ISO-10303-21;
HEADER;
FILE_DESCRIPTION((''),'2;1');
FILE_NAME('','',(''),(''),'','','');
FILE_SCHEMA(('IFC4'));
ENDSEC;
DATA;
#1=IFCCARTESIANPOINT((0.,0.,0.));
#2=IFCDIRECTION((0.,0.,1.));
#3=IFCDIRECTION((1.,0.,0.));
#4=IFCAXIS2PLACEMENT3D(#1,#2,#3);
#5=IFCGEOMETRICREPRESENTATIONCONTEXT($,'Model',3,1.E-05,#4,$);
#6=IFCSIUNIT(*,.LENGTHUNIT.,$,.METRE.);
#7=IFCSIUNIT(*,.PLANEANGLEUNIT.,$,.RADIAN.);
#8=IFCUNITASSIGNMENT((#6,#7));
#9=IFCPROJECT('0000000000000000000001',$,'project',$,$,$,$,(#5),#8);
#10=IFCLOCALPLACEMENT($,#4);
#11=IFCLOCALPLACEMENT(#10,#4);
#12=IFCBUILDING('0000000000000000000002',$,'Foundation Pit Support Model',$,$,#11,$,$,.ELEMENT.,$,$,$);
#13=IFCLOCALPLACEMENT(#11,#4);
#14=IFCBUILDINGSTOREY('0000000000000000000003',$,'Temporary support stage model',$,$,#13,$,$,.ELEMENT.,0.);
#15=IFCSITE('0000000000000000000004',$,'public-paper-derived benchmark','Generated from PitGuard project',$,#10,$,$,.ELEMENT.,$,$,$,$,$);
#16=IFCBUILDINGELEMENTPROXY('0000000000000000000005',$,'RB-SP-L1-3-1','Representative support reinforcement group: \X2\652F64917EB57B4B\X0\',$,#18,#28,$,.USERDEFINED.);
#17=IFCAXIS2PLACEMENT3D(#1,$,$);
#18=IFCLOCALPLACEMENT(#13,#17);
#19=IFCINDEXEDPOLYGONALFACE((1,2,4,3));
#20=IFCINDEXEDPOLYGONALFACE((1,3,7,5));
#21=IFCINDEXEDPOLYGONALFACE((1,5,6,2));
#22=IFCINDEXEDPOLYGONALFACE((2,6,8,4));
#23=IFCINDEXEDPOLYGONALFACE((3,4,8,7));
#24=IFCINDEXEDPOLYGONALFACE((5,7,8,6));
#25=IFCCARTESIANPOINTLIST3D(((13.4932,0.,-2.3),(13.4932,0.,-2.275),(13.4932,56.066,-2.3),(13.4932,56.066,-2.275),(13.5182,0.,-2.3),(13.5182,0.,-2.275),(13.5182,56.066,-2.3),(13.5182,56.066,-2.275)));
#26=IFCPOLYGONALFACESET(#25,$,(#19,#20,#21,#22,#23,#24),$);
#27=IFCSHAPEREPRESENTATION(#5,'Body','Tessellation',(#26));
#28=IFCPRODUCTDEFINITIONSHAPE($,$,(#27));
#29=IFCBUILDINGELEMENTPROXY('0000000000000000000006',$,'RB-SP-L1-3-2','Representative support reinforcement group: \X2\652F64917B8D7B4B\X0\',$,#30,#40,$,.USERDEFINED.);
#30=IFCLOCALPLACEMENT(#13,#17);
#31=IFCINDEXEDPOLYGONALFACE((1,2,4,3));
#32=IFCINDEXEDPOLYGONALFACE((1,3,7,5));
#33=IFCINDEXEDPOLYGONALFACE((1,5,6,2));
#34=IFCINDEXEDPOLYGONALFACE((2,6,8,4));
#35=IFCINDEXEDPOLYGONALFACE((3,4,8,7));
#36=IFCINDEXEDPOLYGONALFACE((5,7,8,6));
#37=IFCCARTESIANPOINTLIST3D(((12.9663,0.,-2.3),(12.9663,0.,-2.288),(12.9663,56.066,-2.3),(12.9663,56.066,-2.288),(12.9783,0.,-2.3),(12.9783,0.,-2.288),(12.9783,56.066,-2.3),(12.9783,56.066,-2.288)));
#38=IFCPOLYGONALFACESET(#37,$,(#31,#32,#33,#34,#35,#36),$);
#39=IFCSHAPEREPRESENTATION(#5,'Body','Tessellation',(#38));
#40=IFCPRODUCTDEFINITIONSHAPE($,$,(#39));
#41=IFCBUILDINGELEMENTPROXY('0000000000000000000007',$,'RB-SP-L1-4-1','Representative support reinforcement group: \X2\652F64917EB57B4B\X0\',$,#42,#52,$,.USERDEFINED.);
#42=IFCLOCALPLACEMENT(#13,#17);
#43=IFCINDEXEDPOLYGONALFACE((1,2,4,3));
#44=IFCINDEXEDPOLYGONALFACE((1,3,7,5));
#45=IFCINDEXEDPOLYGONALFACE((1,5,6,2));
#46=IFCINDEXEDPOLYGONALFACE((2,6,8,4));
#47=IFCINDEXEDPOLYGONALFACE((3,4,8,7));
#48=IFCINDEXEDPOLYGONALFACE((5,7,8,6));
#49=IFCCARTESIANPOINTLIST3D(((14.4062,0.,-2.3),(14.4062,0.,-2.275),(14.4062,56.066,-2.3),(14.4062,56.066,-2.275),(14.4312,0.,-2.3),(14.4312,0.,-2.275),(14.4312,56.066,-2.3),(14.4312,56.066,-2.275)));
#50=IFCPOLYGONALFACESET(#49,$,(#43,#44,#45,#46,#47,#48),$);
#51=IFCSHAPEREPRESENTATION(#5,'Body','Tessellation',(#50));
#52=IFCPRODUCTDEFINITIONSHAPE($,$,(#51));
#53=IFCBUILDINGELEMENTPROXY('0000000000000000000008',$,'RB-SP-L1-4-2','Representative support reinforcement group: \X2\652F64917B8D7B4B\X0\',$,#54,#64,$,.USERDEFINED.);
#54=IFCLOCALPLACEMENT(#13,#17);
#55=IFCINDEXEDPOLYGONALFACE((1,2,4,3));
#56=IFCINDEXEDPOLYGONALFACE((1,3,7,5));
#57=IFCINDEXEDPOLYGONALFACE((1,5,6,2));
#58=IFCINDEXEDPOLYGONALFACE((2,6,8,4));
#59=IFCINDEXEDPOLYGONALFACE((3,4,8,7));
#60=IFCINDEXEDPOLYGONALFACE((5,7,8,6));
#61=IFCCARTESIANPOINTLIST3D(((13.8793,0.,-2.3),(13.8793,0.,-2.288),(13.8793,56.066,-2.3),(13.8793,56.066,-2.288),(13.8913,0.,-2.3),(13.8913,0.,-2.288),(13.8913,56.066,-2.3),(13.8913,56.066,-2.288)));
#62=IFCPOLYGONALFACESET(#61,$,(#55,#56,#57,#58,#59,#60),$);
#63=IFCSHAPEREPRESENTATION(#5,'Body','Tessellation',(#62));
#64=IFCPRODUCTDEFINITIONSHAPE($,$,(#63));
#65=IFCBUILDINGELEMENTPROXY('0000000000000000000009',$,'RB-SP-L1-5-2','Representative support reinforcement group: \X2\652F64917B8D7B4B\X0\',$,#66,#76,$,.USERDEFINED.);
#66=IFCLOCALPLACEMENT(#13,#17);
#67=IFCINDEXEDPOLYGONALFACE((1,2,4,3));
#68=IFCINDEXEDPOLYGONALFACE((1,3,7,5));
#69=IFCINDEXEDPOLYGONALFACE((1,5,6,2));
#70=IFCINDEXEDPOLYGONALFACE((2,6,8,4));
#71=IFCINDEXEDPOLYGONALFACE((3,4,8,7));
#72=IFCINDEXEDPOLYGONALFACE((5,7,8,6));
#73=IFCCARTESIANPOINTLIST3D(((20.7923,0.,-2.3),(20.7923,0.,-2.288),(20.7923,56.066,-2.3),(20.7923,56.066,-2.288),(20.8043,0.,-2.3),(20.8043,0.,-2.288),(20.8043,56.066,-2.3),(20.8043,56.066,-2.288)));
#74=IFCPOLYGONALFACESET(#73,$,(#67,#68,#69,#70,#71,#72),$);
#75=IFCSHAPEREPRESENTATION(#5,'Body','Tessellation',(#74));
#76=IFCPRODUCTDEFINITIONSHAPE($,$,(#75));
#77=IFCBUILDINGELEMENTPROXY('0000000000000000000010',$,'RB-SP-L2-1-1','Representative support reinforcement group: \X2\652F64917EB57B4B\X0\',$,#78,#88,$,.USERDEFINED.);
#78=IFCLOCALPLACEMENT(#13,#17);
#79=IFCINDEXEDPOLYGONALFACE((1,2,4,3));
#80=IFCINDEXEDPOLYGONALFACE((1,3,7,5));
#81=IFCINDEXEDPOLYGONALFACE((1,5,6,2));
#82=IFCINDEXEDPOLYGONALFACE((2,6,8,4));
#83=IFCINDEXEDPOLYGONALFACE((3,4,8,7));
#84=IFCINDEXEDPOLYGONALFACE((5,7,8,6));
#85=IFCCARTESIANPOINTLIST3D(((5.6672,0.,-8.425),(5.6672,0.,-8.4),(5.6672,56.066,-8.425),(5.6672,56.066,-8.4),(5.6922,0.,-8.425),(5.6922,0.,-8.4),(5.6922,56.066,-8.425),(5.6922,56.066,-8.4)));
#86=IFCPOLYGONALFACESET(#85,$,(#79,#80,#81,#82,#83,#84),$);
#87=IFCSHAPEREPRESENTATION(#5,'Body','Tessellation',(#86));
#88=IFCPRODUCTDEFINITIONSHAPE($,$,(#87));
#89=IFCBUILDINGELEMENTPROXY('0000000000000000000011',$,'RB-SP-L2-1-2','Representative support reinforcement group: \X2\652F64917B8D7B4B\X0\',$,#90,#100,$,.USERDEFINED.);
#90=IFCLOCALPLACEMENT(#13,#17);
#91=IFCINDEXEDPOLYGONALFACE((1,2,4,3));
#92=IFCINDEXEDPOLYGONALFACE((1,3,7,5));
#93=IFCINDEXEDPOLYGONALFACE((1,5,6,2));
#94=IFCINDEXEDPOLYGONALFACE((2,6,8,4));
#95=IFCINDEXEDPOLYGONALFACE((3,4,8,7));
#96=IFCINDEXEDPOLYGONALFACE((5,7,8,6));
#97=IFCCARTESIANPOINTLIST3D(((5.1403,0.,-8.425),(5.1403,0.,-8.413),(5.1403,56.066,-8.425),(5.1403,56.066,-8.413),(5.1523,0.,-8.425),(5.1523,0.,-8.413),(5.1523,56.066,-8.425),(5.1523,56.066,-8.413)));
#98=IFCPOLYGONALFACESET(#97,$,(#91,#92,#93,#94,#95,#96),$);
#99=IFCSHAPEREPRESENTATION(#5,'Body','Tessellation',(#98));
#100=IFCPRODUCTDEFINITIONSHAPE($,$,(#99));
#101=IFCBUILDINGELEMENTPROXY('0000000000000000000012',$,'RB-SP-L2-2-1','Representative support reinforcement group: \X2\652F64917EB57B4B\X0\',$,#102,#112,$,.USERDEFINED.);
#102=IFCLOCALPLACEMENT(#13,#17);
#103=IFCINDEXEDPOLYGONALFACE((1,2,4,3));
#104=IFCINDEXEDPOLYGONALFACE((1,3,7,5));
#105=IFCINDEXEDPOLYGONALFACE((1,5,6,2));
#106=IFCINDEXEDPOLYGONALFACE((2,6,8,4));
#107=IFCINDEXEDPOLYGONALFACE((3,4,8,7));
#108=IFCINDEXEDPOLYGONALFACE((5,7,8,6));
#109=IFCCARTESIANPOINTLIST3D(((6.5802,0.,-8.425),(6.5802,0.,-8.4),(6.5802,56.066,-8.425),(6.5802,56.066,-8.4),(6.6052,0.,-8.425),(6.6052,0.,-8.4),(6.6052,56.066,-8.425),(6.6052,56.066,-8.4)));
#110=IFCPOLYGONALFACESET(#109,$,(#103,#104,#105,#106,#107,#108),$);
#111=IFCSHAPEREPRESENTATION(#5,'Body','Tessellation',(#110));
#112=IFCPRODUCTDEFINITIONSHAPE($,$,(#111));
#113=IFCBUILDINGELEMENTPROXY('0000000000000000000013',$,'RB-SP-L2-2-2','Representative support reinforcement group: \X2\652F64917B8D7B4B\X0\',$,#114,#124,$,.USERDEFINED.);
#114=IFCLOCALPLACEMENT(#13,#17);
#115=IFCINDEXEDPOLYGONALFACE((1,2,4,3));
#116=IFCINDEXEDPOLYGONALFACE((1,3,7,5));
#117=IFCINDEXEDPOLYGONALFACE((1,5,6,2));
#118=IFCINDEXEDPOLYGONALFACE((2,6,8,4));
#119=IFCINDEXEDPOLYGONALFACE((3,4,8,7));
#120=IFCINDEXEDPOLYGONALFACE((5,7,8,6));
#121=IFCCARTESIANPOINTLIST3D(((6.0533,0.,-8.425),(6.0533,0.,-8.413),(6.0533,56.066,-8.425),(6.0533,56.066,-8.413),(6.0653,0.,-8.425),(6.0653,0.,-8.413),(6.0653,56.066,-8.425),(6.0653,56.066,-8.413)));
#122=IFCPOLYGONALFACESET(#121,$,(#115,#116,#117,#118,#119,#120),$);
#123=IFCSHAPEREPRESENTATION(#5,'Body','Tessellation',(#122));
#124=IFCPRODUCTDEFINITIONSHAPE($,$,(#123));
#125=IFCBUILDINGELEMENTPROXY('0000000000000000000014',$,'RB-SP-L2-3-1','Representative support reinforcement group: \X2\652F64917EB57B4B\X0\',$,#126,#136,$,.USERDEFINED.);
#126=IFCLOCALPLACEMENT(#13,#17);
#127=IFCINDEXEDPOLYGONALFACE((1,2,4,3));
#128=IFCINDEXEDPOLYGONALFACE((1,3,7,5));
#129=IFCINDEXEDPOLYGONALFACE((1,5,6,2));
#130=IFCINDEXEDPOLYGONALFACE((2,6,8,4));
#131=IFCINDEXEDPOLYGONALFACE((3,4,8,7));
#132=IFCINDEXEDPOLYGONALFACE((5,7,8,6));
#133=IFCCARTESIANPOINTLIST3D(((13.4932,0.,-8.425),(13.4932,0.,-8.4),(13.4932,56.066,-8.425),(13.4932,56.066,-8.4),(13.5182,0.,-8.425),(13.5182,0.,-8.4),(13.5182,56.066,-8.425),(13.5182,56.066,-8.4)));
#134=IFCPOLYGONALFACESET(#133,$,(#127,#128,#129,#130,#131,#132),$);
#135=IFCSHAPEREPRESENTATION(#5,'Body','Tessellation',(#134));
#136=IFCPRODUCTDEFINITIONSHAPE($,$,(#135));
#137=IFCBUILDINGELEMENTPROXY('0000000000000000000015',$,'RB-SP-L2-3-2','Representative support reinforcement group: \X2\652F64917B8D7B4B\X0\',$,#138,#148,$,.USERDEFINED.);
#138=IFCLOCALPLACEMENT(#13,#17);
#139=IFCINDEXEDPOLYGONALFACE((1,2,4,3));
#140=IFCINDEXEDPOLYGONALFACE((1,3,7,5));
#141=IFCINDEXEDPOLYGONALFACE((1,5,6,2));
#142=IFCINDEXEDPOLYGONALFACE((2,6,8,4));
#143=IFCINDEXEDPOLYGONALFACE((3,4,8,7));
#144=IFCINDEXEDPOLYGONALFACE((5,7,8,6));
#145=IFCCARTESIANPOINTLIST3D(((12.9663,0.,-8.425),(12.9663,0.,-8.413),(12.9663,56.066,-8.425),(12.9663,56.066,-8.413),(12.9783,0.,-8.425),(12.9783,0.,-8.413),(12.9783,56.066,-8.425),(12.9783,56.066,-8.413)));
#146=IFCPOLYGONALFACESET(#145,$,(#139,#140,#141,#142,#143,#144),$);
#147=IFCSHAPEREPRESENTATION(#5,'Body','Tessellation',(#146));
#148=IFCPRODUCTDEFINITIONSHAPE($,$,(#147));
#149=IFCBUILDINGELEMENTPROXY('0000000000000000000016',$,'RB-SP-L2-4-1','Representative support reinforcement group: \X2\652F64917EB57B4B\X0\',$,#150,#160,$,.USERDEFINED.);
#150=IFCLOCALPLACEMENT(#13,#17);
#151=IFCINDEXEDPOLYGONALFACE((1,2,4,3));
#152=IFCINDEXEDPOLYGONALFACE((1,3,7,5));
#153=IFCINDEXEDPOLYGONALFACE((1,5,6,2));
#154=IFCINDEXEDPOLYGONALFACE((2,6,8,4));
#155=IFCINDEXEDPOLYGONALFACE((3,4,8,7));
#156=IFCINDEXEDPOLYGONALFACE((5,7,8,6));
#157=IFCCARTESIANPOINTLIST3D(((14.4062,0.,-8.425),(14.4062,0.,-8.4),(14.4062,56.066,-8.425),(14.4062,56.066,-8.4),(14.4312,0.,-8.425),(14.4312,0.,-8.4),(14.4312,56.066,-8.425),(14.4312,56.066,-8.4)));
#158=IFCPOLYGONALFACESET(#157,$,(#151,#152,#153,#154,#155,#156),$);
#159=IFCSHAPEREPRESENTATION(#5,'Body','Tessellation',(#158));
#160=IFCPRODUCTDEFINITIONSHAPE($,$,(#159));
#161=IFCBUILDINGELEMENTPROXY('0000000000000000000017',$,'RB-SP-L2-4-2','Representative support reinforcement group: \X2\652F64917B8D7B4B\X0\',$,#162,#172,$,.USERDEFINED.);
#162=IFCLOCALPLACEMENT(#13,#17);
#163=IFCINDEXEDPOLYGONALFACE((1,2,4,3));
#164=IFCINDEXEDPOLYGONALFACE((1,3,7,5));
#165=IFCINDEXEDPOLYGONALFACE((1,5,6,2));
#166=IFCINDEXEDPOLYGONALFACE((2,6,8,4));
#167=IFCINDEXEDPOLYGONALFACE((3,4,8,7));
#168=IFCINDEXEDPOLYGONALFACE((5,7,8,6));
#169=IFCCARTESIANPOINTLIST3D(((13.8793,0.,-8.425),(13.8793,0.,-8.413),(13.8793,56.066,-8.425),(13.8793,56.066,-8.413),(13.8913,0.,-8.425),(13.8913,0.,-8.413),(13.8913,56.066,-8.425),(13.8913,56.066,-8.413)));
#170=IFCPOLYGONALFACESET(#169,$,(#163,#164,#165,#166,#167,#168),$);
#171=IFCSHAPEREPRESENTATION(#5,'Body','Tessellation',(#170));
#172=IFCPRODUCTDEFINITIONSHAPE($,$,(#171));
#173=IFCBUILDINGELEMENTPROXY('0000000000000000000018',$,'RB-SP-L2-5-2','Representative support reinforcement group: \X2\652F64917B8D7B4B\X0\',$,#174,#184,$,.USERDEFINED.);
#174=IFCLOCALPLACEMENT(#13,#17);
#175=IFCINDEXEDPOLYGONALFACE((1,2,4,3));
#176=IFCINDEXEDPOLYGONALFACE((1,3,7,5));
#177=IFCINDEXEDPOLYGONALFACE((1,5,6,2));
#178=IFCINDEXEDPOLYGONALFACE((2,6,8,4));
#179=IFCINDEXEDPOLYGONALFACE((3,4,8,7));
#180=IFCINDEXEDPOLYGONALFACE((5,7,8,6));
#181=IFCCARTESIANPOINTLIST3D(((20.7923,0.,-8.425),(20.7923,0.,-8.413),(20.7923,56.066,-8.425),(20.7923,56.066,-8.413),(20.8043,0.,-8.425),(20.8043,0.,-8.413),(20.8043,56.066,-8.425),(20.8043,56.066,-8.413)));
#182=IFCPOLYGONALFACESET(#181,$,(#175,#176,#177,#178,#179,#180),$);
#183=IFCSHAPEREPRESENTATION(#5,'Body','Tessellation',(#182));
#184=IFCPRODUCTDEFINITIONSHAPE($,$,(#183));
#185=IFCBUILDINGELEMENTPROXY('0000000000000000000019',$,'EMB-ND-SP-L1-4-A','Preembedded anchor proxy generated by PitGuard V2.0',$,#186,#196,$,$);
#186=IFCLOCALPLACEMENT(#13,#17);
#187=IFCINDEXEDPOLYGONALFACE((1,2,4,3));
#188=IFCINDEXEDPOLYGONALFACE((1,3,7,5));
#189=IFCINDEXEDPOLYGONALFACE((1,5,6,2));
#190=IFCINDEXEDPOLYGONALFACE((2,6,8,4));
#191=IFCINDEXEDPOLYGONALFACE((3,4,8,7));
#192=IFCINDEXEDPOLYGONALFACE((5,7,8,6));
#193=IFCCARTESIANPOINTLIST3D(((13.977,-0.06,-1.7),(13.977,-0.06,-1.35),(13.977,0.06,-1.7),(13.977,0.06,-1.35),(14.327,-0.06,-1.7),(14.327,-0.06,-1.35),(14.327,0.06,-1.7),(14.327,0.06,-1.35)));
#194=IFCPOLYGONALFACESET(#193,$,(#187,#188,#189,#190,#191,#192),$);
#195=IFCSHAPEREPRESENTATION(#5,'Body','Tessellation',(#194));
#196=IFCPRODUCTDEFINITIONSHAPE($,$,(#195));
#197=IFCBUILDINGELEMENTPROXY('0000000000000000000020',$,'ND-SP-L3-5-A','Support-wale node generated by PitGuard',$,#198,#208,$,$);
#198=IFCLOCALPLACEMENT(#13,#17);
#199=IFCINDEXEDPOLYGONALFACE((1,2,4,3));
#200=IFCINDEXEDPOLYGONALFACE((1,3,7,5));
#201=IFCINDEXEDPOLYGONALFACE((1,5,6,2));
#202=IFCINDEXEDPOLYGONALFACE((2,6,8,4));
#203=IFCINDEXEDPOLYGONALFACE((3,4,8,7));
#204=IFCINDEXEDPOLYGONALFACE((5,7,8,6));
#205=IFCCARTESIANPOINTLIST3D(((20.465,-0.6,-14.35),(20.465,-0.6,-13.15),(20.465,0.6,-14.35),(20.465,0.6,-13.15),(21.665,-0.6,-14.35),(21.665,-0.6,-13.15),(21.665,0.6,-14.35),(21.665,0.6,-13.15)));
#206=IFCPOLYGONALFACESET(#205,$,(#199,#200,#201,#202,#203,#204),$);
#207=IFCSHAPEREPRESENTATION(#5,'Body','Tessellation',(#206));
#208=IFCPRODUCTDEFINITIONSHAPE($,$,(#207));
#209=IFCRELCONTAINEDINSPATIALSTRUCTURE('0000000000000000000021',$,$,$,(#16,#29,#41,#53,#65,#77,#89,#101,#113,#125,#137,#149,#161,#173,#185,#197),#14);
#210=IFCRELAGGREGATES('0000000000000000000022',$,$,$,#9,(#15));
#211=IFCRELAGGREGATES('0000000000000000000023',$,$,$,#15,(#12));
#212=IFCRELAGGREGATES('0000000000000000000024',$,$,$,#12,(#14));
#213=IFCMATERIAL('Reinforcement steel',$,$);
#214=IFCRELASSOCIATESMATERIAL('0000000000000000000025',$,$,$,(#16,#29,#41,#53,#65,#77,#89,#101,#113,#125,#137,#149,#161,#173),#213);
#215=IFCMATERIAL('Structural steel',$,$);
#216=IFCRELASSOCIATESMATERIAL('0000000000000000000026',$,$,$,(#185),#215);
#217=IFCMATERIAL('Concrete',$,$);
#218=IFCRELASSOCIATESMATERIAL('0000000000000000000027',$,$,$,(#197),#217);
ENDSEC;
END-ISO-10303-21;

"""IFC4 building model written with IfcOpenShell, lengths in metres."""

from ifc_helpers import new_model, si_unit, frame, origin_with_axes, origin_2d, place, context, project, spatial, rectangle, extrude, material, element, save


model = new_model("IFC4")

# Units and contexts
model_context = context("Model", 3, precision=1e-05, world=origin_with_axes())
ifc_project = project(units=[si_unit("LENGTHUNIT", "METRE"), si_unit("PLANEANGLEUNIT", "RADIAN")], contexts=[model_context])

# Site, building, storey
site_placement = place(None, origin_with_axes())
site = spatial("IfcSite", under=ifc_project, at=site_placement, Name="public-paper-derived benchmark", Description="Generated from PitGuard project", CompositionType="ELEMENT")
building_placement = place(site_placement, origin_with_axes())
building = spatial("IfcBuilding", under=site, at=building_placement, Name="Foundation Pit Support Model", CompositionType="ELEMENT")
storey_placement = place(building_placement, origin_with_axes())
storey = spatial("IfcBuildingStorey", under=building, at=storey_placement, Name="Temporary support stage model", CompositionType="ELEMENT", Elevation=0.0)

# Shared definitions
ifc_material_1 = material(Name="Concrete")

# Shared definitions
ifc_material_2 = material(Name="Structural steel")

# Building element proxies
ifc_material_3 = material(Name="Reinforcement steel")
proxy_1_placement = place(storey_placement, frame((13.5057, 28.033, -2.3), z_axis=(0.0, 0.0, 1.0), x_axis=(0.0, 1.0, 0.0)))
element("IfcBuildingElementProxy", 1, at=proxy_1_placement, inside=storey, material=ifc_material_3, Name="RB-SP-L1-3-1", Description="Representative support reinforcement group: 支撑纵筋", PredefinedType="USERDEFINED", context=model_context, shape_type="SweptSolid", body=[
    extrude(rectangle(XDim=56.066, YDim=0.025, at=origin_2d()), origin_with_axes(), (0.0, 0.0, 1.0), 0.025),
])
proxy_2_placement = place(storey_placement, frame((12.9723, 28.033, -2.3), z_axis=(0.0, 0.0, 1.0), x_axis=(0.0, 1.0, 0.0)))
element("IfcBuildingElementProxy", 2, at=proxy_2_placement, inside=storey, material=ifc_material_3, Name="RB-SP-L1-3-2", Description="Representative support reinforcement group: 支撑箍筋", PredefinedType="USERDEFINED", context=model_context, shape_type="SweptSolid", body=[
    extrude(rectangle(XDim=56.066, YDim=0.012, at=origin_2d()), origin_with_axes(), (0.0, 0.0, 1.0), 0.012),
])
proxy_3_placement = place(storey_placement, frame((14.4187, 28.033, -2.3), z_axis=(0.0, 0.0, 1.0), x_axis=(0.0, 1.0, 0.0)))
element("IfcBuildingElementProxy", 3, at=proxy_3_placement, inside=storey, material=ifc_material_3, Name="RB-SP-L1-4-1", Description="Representative support reinforcement group: 支撑纵筋", PredefinedType="USERDEFINED", context=model_context, shape_type="SweptSolid", body=[
    extrude(rectangle(XDim=56.066, YDim=0.025, at=origin_2d()), origin_with_axes(), (0.0, 0.0, 1.0), 0.025),
])
for number, where, z_axis, x_axis, name in (
    (4, (13.8853, 28.033, -2.3), (0.0, 0.0, 1.0), (0.0, 1.0, 0.0), "RB-SP-L1-4-2"),
    (5, (20.7983, 28.033, -2.3), (0.0, 0.0, 1.0), (0.0, 1.0, 0.0), "RB-SP-L1-5-2"),
):
    element("IfcBuildingElementProxy", number, at=place(storey_placement, frame(where, z_axis=z_axis, x_axis=x_axis)), inside=storey, material=ifc_material_3, Name=name, Description="Representative support reinforcement group: 支撑箍筋", PredefinedType="USERDEFINED", context=model_context, shape_type="SweptSolid", body=[
        extrude(rectangle(XDim=56.066, YDim=0.012, at=origin_2d()), origin_with_axes(), (0.0, 0.0, 1.0), 0.012),
    ])
proxy_4_placement = place(storey_placement, frame((5.6797, 28.033, -8.425), z_axis=(0.0, 0.0, 1.0), x_axis=(0.0, 1.0, 0.0)))
element("IfcBuildingElementProxy", 6, at=proxy_4_placement, inside=storey, material=ifc_material_3, Name="RB-SP-L2-1-1", Description="Representative support reinforcement group: 支撑纵筋", PredefinedType="USERDEFINED", context=model_context, shape_type="SweptSolid", body=[
    extrude(rectangle(XDim=56.066, YDim=0.025, at=origin_2d()), origin_with_axes(), (0.0, 0.0, 1.0), 0.025),
])
proxy_5_placement = place(storey_placement, frame((5.1463, 28.033, -8.425), z_axis=(0.0, 0.0, 1.0), x_axis=(0.0, 1.0, 0.0)))
element("IfcBuildingElementProxy", 7, at=proxy_5_placement, inside=storey, material=ifc_material_3, Name="RB-SP-L2-1-2", Description="Representative support reinforcement group: 支撑箍筋", PredefinedType="USERDEFINED", context=model_context, shape_type="SweptSolid", body=[
    extrude(rectangle(XDim=56.066, YDim=0.012, at=origin_2d()), origin_with_axes(), (0.0, 0.0, 1.0), 0.012),
])
proxy_6_placement = place(storey_placement, frame((6.5927, 28.033, -8.425), z_axis=(0.0, 0.0, 1.0), x_axis=(0.0, 1.0, 0.0)))
element("IfcBuildingElementProxy", 8, at=proxy_6_placement, inside=storey, material=ifc_material_3, Name="RB-SP-L2-2-1", Description="Representative support reinforcement group: 支撑纵筋", PredefinedType="USERDEFINED", context=model_context, shape_type="SweptSolid", body=[
    extrude(rectangle(XDim=56.066, YDim=0.025, at=origin_2d()), origin_with_axes(), (0.0, 0.0, 1.0), 0.025),
])
proxy_7_placement = place(storey_placement, frame((6.0593, 28.033, -8.425), z_axis=(0.0, 0.0, 1.0), x_axis=(0.0, 1.0, 0.0)))
element("IfcBuildingElementProxy", 9, at=proxy_7_placement, inside=storey, material=ifc_material_3, Name="RB-SP-L2-2-2", Description="Representative support reinforcement group: 支撑箍筋", PredefinedType="USERDEFINED", context=model_context, shape_type="SweptSolid", body=[
    extrude(rectangle(XDim=56.066, YDim=0.012, at=origin_2d()), origin_with_axes(), (0.0, 0.0, 1.0), 0.012),
])
proxy_8_placement = place(storey_placement, frame((13.5057, 28.033, -8.425), z_axis=(0.0, 0.0, 1.0), x_axis=(0.0, 1.0, 0.0)))
element("IfcBuildingElementProxy", 10, at=proxy_8_placement, inside=storey, material=ifc_material_3, Name="RB-SP-L2-3-1", Description="Representative support reinforcement group: 支撑纵筋", PredefinedType="USERDEFINED", context=model_context, shape_type="SweptSolid", body=[
    extrude(rectangle(XDim=56.066, YDim=0.025, at=origin_2d()), origin_with_axes(), (0.0, 0.0, 1.0), 0.025),
])
proxy_9_placement = place(storey_placement, frame((12.9723, 28.033, -8.425), z_axis=(0.0, 0.0, 1.0), x_axis=(0.0, 1.0, 0.0)))
element("IfcBuildingElementProxy", 11, at=proxy_9_placement, inside=storey, material=ifc_material_3, Name="RB-SP-L2-3-2", Description="Representative support reinforcement group: 支撑箍筋", PredefinedType="USERDEFINED", context=model_context, shape_type="SweptSolid", body=[
    extrude(rectangle(XDim=56.066, YDim=0.012, at=origin_2d()), origin_with_axes(), (0.0, 0.0, 1.0), 0.012),
])
proxy_10_placement = place(storey_placement, frame((14.4187, 28.033, -8.425), z_axis=(0.0, 0.0, 1.0), x_axis=(0.0, 1.0, 0.0)))
element("IfcBuildingElementProxy", 12, at=proxy_10_placement, inside=storey, material=ifc_material_3, Name="RB-SP-L2-4-1", Description="Representative support reinforcement group: 支撑纵筋", PredefinedType="USERDEFINED", context=model_context, shape_type="SweptSolid", body=[
    extrude(rectangle(XDim=56.066, YDim=0.025, at=origin_2d()), origin_with_axes(), (0.0, 0.0, 1.0), 0.025),
])
for number, where, z_axis, x_axis, name in (
    (13, (13.8853, 28.033, -8.425), (0.0, 0.0, 1.0), (0.0, 1.0, 0.0), "RB-SP-L2-4-2"),
    (14, (20.7983, 28.033, -8.425), (0.0, 0.0, 1.0), (0.0, 1.0, 0.0), "RB-SP-L2-5-2"),
):
    element("IfcBuildingElementProxy", number, at=place(storey_placement, frame(where, z_axis=z_axis, x_axis=x_axis)), inside=storey, material=ifc_material_3, Name=name, Description="Representative support reinforcement group: 支撑箍筋", PredefinedType="USERDEFINED", context=model_context, shape_type="SweptSolid", body=[
        extrude(rectangle(XDim=56.066, YDim=0.012, at=origin_2d()), origin_with_axes(), (0.0, 0.0, 1.0), 0.012),
    ])
proxy_11_placement = place(storey_placement, frame((14.152, 0.0, -1.7), z_axis=(0.0, 0.0, 1.0), x_axis=(1.0, 0.0, 0.0)))
element("IfcBuildingElementProxy", 15, at=proxy_11_placement, inside=storey, material=ifc_material_2, Name="EMB-ND-SP-L1-4-A", Description="Preembedded anchor proxy generated by PitGuard V2.0", context=model_context, shape_type="SweptSolid", body=[
    extrude(rectangle(XDim=0.35, YDim=0.12, at=origin_2d()), origin_with_axes(), (0.0, 0.0, 1.0), 0.35),
])
proxy_12_placement = place(storey_placement, frame((21.065, 0.0, -14.35), z_axis=(0.0, 0.0, 1.0), x_axis=(1.0, 0.0, 0.0)))
element("IfcBuildingElementProxy", 16, at=proxy_12_placement, inside=storey, material=ifc_material_1, Name="ND-SP-L3-5-A", Description="Support-wale node generated by PitGuard", context=model_context, shape_type="SweptSolid", body=[
    extrude(rectangle(XDim=1.2, YDim=1.2, at=origin_2d()), origin_with_axes(), (0.0, 0.0, 1.0), 1.2),
])

save(model, "model.ifc")
